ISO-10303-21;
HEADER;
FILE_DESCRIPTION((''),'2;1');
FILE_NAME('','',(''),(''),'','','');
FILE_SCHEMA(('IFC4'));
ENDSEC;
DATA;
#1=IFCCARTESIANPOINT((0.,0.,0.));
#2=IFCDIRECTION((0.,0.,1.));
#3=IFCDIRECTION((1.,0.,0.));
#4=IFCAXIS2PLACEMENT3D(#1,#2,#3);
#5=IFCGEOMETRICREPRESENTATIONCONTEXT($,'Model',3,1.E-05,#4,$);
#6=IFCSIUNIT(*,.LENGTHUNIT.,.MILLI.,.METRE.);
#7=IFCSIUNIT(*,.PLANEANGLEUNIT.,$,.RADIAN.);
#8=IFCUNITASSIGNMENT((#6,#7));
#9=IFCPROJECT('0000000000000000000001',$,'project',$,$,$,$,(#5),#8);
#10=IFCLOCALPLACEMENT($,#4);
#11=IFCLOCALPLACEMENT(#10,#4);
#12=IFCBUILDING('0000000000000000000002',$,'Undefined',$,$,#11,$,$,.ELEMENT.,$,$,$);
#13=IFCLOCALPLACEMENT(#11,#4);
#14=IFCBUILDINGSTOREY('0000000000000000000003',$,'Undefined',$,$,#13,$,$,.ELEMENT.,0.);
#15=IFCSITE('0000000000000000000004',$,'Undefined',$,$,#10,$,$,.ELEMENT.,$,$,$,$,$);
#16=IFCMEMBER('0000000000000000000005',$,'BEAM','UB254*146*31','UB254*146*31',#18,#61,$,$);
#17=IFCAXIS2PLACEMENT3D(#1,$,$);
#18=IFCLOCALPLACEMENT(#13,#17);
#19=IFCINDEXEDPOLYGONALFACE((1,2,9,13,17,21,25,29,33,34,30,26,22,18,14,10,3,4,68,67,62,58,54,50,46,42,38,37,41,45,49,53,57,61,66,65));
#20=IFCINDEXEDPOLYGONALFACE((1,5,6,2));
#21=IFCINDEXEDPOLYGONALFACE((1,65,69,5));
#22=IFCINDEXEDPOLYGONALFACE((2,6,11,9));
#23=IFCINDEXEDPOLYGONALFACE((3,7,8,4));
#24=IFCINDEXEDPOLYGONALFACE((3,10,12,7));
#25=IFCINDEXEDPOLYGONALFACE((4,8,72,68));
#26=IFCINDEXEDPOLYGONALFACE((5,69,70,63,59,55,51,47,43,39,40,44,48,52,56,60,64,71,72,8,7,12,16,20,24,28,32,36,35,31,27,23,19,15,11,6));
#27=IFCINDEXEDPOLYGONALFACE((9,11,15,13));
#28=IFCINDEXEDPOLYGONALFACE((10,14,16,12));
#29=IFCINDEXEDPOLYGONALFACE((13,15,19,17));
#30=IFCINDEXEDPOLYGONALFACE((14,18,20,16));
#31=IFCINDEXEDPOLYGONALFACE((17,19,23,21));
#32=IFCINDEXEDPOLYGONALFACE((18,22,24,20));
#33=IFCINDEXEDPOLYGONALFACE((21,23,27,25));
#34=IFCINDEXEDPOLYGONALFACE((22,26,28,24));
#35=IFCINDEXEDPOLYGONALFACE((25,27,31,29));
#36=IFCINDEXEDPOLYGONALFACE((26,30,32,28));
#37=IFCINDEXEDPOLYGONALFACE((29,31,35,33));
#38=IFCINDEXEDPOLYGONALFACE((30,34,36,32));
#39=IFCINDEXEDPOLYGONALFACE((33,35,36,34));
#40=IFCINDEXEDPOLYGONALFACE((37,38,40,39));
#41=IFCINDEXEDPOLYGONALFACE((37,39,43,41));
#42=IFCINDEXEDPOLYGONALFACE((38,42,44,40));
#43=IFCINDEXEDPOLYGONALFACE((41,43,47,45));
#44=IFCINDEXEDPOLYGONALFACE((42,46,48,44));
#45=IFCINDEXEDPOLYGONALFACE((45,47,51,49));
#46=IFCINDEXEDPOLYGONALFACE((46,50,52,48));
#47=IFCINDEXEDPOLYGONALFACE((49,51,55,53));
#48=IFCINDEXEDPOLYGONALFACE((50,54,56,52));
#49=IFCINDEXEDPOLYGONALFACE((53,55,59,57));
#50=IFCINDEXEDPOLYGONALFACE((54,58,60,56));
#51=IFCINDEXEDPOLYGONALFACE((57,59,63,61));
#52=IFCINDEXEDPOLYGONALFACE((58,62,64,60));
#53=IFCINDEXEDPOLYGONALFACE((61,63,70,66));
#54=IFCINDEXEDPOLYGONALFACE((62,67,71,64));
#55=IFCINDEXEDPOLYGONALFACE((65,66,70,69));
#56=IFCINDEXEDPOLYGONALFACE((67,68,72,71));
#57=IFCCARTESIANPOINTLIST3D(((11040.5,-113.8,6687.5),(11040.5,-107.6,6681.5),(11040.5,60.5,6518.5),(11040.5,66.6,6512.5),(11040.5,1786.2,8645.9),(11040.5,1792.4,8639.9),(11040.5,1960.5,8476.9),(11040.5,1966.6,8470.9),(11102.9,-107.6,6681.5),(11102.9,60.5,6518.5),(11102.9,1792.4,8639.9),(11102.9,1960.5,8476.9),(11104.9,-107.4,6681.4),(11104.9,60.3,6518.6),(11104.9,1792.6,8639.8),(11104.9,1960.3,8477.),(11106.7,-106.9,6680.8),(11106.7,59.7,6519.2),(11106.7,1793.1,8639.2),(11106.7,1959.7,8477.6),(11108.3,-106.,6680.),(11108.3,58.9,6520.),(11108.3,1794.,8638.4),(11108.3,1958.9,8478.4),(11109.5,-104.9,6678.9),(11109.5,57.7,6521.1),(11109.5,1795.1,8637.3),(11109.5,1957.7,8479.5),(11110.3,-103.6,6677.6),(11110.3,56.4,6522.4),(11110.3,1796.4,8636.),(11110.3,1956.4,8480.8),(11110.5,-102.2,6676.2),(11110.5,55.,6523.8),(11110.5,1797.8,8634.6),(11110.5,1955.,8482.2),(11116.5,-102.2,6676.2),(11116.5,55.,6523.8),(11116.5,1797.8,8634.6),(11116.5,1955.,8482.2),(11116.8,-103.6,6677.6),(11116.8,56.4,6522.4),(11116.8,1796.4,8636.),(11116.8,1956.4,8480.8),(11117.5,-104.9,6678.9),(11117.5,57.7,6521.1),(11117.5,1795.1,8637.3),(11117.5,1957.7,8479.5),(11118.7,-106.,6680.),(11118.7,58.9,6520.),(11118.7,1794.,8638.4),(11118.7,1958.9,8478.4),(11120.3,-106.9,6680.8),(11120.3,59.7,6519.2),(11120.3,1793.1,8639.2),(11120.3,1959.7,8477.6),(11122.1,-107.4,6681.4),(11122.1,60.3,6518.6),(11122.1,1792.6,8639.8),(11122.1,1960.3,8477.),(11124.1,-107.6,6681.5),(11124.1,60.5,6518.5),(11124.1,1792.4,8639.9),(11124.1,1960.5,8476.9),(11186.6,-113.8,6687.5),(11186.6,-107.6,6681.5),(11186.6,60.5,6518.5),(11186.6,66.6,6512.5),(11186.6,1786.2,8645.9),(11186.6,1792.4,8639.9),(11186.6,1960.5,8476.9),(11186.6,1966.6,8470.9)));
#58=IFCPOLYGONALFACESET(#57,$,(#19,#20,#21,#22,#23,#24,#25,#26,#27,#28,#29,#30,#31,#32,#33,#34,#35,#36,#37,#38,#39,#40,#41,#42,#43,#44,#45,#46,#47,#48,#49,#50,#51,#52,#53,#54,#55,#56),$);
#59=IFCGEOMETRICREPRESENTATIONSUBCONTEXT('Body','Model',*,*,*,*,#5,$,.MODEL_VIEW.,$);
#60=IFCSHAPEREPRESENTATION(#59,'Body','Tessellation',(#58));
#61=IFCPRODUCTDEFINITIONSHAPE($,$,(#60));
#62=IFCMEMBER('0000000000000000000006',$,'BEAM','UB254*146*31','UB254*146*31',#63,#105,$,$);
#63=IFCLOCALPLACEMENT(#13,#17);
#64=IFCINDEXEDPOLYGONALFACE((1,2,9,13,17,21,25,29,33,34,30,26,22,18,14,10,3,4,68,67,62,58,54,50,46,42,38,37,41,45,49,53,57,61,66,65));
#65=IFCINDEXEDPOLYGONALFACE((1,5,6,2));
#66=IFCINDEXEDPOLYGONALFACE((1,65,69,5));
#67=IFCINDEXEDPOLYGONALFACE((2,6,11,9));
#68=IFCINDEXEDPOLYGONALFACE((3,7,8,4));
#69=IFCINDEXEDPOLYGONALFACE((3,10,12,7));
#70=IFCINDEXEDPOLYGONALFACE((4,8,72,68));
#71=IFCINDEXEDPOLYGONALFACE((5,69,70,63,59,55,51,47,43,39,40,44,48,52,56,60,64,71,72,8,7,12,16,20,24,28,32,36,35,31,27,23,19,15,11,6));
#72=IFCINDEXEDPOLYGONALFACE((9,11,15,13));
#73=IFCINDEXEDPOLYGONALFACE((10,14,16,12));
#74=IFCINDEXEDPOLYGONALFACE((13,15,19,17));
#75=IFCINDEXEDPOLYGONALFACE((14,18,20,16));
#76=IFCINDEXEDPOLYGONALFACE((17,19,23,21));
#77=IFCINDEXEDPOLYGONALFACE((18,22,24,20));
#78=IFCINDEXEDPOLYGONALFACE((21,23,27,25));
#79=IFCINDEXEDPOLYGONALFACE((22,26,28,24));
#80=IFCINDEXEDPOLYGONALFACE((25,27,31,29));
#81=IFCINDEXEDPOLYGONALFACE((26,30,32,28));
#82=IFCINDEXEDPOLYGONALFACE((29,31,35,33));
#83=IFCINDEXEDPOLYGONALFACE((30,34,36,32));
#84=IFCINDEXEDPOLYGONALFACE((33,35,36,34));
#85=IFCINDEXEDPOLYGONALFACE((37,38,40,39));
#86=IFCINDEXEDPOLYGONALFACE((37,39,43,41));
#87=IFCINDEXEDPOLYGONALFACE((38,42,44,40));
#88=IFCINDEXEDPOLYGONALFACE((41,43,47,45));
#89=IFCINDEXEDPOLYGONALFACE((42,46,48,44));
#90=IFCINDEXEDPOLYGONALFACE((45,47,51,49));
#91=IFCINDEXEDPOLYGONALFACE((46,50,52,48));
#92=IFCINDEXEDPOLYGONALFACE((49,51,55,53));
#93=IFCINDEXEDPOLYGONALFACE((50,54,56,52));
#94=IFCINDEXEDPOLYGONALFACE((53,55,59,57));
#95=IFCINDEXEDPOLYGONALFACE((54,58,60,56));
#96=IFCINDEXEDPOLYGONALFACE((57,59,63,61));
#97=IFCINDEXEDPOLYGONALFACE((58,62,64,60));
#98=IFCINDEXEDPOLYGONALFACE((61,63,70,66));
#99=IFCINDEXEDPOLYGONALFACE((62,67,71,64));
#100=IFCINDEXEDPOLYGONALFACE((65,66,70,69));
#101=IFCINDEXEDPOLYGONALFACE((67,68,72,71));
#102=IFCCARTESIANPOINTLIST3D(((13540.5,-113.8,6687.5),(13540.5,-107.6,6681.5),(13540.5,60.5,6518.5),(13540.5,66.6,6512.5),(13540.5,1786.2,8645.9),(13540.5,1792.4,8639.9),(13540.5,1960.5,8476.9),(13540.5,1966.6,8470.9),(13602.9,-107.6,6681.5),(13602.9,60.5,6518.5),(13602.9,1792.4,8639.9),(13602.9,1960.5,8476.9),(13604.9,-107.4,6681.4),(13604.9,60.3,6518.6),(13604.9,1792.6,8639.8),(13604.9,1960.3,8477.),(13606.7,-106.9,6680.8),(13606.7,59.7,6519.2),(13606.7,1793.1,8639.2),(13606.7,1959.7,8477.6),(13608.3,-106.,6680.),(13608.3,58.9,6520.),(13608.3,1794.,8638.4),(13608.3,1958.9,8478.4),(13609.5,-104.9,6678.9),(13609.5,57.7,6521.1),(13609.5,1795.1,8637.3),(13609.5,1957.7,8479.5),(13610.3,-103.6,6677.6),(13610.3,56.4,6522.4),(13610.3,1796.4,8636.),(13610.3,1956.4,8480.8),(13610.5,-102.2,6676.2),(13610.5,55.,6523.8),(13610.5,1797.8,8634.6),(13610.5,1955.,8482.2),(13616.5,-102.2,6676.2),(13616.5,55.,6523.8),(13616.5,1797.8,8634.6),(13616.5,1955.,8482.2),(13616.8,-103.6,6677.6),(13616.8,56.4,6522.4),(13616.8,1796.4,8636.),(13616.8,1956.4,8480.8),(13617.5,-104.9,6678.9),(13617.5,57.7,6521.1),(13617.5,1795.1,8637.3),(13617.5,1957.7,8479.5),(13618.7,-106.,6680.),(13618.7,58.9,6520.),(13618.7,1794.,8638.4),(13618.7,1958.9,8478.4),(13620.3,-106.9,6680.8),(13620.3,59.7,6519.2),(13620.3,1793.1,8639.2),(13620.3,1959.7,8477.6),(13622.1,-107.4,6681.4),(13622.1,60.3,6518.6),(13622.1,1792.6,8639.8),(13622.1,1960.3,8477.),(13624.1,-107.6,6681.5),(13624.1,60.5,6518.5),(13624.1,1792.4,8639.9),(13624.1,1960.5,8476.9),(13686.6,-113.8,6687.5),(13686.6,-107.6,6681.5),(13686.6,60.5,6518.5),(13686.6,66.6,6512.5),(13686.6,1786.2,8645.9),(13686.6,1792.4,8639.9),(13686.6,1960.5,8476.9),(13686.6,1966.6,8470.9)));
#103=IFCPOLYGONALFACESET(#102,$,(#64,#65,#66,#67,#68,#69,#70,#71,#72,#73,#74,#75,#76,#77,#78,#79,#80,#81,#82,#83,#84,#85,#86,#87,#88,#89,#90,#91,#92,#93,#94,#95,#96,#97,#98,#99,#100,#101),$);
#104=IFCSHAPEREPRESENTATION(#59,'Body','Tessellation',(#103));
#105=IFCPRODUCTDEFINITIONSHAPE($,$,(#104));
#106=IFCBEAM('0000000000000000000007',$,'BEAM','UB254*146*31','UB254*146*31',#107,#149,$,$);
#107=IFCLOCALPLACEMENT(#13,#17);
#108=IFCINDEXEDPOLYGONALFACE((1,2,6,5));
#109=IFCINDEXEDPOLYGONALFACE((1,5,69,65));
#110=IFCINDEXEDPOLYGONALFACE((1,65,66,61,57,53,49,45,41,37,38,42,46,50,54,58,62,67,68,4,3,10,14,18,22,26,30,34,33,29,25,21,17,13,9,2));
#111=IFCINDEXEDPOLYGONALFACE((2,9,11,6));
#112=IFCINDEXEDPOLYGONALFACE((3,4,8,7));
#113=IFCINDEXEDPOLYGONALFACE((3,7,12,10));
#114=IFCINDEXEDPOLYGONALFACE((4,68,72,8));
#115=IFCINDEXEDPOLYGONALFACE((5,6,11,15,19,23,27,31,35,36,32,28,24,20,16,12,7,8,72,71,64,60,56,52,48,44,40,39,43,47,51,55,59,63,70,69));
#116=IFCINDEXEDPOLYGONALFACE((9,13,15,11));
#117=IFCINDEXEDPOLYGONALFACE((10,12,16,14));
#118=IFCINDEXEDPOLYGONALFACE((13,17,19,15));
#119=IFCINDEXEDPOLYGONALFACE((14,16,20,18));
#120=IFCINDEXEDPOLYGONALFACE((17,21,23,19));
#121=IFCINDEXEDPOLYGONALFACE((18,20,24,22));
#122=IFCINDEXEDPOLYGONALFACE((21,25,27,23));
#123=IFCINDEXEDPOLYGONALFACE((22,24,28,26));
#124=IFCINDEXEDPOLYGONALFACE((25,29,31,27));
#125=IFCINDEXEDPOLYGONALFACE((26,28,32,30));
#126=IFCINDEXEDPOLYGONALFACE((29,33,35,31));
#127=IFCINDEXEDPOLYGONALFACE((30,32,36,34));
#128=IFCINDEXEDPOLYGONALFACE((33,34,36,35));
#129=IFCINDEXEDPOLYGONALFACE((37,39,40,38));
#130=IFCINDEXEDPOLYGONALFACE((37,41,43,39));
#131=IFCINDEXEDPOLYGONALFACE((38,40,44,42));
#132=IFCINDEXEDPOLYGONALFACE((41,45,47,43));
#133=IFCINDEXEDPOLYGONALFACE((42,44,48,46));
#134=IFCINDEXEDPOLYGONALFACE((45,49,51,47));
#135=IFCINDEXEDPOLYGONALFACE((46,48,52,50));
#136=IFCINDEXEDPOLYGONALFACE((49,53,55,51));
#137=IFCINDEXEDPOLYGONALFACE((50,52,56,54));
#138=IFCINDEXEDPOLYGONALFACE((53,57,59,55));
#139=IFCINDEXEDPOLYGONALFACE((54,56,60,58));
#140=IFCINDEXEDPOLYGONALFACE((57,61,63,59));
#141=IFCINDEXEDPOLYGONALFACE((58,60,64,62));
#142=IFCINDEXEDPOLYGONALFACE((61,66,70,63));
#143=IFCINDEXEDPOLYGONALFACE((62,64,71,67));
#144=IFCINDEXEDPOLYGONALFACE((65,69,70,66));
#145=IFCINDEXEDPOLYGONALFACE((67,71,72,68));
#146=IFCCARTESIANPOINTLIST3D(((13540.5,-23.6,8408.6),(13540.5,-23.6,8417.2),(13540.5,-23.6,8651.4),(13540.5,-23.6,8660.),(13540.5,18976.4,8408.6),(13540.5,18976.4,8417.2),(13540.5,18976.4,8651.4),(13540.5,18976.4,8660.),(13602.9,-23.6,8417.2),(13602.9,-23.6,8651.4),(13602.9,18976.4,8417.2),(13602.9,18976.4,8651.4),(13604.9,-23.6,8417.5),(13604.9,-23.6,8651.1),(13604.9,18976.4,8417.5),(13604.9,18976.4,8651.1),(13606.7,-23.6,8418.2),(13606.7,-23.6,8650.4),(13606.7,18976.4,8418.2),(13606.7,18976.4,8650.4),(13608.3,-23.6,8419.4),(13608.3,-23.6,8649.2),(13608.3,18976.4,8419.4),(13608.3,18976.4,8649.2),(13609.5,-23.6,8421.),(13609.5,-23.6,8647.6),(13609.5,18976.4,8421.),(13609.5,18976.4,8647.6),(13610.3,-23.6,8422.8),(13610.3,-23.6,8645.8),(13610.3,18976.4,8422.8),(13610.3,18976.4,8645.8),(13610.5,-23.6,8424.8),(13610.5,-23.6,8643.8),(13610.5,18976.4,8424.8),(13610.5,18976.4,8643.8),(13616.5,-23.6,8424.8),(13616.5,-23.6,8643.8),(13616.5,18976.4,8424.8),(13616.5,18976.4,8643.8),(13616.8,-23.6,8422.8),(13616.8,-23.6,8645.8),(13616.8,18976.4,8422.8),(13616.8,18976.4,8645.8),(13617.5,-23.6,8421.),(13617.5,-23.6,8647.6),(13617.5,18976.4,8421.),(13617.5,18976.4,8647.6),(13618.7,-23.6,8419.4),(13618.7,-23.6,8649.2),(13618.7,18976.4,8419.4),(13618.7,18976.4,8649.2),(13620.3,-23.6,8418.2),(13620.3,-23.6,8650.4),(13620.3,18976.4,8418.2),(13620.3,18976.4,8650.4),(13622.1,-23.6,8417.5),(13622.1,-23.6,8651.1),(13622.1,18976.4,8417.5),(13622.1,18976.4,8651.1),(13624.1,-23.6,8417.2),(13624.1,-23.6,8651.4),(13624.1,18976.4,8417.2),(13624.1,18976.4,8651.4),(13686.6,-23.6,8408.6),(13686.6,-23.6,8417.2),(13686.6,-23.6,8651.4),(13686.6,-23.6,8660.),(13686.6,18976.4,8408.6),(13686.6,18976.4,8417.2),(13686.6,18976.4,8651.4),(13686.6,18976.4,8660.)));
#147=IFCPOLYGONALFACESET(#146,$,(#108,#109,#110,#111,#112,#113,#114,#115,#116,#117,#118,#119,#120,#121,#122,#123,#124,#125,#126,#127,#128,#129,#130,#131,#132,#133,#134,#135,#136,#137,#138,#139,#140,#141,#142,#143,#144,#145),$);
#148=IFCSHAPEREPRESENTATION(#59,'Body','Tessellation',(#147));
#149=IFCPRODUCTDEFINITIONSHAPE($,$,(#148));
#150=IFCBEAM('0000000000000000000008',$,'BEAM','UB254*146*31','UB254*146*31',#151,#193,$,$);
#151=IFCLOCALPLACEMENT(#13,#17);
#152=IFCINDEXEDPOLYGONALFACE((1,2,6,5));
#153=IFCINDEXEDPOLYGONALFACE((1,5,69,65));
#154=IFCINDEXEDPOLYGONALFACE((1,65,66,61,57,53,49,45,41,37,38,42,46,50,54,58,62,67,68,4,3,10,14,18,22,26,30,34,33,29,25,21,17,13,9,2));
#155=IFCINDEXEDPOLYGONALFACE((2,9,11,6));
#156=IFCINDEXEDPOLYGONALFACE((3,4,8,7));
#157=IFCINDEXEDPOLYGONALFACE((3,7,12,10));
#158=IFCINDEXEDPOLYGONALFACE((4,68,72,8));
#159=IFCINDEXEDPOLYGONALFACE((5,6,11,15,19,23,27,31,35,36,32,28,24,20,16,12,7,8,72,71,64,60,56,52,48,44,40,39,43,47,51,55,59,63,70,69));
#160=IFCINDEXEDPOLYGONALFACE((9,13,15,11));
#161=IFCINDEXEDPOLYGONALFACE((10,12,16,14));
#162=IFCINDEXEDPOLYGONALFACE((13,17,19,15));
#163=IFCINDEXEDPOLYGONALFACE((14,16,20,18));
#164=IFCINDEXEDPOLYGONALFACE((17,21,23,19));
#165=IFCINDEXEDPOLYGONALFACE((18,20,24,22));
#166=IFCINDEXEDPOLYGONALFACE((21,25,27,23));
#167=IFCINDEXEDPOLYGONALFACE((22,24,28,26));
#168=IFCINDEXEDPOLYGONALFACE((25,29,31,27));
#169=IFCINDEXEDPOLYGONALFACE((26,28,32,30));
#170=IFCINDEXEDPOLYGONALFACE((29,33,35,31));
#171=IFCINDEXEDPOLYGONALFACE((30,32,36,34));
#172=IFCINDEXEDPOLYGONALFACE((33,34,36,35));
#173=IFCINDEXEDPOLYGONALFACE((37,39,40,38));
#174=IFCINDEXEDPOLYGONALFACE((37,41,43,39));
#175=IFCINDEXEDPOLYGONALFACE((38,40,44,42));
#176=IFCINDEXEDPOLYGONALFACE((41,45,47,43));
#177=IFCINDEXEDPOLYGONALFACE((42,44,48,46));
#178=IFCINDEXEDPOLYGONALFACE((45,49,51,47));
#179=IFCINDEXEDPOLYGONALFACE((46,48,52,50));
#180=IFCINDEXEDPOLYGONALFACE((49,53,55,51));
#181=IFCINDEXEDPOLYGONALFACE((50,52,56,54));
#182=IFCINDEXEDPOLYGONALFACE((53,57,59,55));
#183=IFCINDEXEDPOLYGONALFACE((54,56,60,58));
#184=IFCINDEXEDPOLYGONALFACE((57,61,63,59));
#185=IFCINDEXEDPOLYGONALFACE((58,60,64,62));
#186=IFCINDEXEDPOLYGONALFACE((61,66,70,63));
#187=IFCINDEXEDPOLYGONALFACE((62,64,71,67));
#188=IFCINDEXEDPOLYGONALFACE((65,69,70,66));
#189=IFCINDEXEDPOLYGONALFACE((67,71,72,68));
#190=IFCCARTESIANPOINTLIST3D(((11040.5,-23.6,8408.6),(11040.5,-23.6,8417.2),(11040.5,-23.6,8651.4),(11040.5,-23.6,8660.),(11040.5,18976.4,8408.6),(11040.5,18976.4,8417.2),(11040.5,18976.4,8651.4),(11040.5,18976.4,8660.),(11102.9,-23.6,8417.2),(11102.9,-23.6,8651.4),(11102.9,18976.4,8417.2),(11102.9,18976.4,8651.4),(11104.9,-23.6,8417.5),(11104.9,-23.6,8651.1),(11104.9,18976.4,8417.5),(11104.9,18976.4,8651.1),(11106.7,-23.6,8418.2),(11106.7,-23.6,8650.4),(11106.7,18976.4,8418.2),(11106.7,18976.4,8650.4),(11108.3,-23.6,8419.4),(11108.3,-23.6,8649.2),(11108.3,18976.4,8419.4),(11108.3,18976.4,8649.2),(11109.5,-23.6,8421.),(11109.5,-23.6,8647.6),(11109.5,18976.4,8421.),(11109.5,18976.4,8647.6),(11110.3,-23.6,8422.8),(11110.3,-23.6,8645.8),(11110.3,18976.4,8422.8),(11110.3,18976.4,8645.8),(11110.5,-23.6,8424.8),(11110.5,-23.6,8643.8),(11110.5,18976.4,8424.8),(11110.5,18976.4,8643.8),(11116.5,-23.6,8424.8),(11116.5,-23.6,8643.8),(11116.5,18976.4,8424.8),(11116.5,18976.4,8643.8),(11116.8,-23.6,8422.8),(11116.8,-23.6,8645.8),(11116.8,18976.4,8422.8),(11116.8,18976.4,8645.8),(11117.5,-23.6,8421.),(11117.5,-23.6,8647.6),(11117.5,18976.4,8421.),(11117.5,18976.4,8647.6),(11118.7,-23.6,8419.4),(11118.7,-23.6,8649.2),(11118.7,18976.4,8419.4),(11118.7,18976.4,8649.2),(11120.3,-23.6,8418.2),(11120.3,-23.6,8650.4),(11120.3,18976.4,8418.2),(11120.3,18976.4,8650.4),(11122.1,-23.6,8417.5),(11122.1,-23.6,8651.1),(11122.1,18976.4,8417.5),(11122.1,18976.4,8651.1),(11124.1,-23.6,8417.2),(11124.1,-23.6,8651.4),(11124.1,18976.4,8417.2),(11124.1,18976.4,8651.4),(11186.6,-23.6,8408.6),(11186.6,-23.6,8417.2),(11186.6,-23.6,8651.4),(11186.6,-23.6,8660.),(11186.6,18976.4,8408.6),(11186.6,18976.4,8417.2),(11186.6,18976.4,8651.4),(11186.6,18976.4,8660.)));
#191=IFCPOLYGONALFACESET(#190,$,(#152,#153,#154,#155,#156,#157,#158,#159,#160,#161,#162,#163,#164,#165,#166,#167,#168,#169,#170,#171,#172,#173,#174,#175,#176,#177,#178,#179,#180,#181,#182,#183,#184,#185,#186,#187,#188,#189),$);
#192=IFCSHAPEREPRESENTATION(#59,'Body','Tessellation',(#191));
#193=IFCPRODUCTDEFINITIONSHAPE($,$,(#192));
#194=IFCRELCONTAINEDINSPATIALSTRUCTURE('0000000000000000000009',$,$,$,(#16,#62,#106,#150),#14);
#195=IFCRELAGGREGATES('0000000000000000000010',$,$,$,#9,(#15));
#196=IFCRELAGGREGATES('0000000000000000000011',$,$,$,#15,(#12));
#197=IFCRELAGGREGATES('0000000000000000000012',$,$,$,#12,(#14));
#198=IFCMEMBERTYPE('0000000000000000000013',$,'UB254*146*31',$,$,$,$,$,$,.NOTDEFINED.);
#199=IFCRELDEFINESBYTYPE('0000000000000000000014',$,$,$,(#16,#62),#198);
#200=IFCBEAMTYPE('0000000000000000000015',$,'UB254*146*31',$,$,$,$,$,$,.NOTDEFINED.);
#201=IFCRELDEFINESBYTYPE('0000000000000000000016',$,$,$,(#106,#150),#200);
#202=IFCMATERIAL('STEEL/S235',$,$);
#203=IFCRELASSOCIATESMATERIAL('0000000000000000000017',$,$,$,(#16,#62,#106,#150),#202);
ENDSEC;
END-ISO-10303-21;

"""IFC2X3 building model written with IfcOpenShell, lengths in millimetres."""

from ifc_helpers import new_model, si_unit, frame, origin_with_axes, origin_2d_with_axis, place, context, subcontext, project, spatial, i_section, extrude, material, type_object, element, save


model = new_model("IFC2X3")

# Units and contexts
model_context = context("Model", 3, precision=1e-05, world=origin_with_axes())
body_context = subcontext(model_context, "Body", "Model", "MODEL_VIEW")
ifc_project = project(units=[si_unit("LENGTHUNIT", "METRE", prefix="MILLI"), si_unit("PLANEANGLEUNIT", "RADIAN")], contexts=[model_context])

# Site, building, storey
site_placement = place(None, origin_with_axes())
site = spatial("IfcSite", under=ifc_project, at=site_placement, Name="Undefined", CompositionType="ELEMENT")
building_placement = place(site_placement, origin_with_axes())
building = spatial("IfcBuilding", under=site, at=building_placement, Name="Undefined", CompositionType="ELEMENT")
storey_placement = place(building_placement, origin_with_axes())
storey = spatial("IfcBuildingStorey", under=building, at=storey_placement, Name="Undefined", CompositionType="ELEMENT", Elevation=0.0)

# Shared definitions
ifc_material = material(Name="STEEL/S235")

# Members
member_type_1 = type_object("IfcMemberType", Name="UB254*146*31", PredefinedType="NOTDEFINED")
for number, where, z_axis, x_axis, name in (
    (1, (11113.5, -23.6, 6600.0), (0.0, -0.717727, 0.696324), (0.0, 0.696324, 0.717727), "BEAM"),
    (2, (13613.5, -23.6, 6600.0), (0.0, -0.717727, 0.696324), (0.0, 0.696324, 0.717727), "BEAM"),
):
    element("IfcMember", number, at=place(storey_placement, frame(where, z_axis=z_axis, x_axis=x_axis)), inside=storey, type_object=member_type_1, material=ifc_material, Name=name, Description="UB254*146*31", ObjectType="UB254*146*31", context=body_context, shape_type="SweptSolid", body=[
        extrude(i_section(OverallWidth=146.1, OverallDepth=251.4, WebThickness=6.0, FlangeThickness=8.6, FilletRadius=7.6, at=origin_2d_with_axis()), frame((2728.6, 0.0, 0.0), z_axis=(-1.0, 0.0, 0.0), x_axis=(0.0, -1.0, 0.0)), (0.0, 0.0, 1.0), 2728.6),
    ])

# Beams
beam_type_1 = type_object("IfcBeamType", Name="UB254*146*31", PredefinedType="NOTDEFINED")
for number, where, z_axis, x_axis, name in (
    (3, (13613.5, -23.6, 8534.3), (0.0, 0.0, 1.0), (0.0, 1.0, 0.0), "BEAM"),
    (4, (11113.5, -23.6, 8534.3), (0.0, 0.0, 1.0), (0.0, 1.0, 0.0), "BEAM"),
):
    element("IfcBeam", number, at=place(storey_placement, frame(where, z_axis=z_axis, x_axis=x_axis)), inside=storey, type_object=beam_type_1, material=ifc_material, Name=name, Description="UB254*146*31", ObjectType="UB254*146*31", context=body_context, shape_type="SweptSolid", body=[
        extrude(i_section(OverallWidth=146.1, OverallDepth=251.4, WebThickness=6.0, FlangeThickness=8.6, FilletRadius=7.6, at=origin_2d_with_axis()), frame((19000.0, 0.0, 0.0), z_axis=(-1.0, 0.0, 0.0), x_axis=(0.0, -1.0, 0.0)), (0.0, 0.0, 1.0), 19000.0),
    ])

save(model, "model.ifc")
